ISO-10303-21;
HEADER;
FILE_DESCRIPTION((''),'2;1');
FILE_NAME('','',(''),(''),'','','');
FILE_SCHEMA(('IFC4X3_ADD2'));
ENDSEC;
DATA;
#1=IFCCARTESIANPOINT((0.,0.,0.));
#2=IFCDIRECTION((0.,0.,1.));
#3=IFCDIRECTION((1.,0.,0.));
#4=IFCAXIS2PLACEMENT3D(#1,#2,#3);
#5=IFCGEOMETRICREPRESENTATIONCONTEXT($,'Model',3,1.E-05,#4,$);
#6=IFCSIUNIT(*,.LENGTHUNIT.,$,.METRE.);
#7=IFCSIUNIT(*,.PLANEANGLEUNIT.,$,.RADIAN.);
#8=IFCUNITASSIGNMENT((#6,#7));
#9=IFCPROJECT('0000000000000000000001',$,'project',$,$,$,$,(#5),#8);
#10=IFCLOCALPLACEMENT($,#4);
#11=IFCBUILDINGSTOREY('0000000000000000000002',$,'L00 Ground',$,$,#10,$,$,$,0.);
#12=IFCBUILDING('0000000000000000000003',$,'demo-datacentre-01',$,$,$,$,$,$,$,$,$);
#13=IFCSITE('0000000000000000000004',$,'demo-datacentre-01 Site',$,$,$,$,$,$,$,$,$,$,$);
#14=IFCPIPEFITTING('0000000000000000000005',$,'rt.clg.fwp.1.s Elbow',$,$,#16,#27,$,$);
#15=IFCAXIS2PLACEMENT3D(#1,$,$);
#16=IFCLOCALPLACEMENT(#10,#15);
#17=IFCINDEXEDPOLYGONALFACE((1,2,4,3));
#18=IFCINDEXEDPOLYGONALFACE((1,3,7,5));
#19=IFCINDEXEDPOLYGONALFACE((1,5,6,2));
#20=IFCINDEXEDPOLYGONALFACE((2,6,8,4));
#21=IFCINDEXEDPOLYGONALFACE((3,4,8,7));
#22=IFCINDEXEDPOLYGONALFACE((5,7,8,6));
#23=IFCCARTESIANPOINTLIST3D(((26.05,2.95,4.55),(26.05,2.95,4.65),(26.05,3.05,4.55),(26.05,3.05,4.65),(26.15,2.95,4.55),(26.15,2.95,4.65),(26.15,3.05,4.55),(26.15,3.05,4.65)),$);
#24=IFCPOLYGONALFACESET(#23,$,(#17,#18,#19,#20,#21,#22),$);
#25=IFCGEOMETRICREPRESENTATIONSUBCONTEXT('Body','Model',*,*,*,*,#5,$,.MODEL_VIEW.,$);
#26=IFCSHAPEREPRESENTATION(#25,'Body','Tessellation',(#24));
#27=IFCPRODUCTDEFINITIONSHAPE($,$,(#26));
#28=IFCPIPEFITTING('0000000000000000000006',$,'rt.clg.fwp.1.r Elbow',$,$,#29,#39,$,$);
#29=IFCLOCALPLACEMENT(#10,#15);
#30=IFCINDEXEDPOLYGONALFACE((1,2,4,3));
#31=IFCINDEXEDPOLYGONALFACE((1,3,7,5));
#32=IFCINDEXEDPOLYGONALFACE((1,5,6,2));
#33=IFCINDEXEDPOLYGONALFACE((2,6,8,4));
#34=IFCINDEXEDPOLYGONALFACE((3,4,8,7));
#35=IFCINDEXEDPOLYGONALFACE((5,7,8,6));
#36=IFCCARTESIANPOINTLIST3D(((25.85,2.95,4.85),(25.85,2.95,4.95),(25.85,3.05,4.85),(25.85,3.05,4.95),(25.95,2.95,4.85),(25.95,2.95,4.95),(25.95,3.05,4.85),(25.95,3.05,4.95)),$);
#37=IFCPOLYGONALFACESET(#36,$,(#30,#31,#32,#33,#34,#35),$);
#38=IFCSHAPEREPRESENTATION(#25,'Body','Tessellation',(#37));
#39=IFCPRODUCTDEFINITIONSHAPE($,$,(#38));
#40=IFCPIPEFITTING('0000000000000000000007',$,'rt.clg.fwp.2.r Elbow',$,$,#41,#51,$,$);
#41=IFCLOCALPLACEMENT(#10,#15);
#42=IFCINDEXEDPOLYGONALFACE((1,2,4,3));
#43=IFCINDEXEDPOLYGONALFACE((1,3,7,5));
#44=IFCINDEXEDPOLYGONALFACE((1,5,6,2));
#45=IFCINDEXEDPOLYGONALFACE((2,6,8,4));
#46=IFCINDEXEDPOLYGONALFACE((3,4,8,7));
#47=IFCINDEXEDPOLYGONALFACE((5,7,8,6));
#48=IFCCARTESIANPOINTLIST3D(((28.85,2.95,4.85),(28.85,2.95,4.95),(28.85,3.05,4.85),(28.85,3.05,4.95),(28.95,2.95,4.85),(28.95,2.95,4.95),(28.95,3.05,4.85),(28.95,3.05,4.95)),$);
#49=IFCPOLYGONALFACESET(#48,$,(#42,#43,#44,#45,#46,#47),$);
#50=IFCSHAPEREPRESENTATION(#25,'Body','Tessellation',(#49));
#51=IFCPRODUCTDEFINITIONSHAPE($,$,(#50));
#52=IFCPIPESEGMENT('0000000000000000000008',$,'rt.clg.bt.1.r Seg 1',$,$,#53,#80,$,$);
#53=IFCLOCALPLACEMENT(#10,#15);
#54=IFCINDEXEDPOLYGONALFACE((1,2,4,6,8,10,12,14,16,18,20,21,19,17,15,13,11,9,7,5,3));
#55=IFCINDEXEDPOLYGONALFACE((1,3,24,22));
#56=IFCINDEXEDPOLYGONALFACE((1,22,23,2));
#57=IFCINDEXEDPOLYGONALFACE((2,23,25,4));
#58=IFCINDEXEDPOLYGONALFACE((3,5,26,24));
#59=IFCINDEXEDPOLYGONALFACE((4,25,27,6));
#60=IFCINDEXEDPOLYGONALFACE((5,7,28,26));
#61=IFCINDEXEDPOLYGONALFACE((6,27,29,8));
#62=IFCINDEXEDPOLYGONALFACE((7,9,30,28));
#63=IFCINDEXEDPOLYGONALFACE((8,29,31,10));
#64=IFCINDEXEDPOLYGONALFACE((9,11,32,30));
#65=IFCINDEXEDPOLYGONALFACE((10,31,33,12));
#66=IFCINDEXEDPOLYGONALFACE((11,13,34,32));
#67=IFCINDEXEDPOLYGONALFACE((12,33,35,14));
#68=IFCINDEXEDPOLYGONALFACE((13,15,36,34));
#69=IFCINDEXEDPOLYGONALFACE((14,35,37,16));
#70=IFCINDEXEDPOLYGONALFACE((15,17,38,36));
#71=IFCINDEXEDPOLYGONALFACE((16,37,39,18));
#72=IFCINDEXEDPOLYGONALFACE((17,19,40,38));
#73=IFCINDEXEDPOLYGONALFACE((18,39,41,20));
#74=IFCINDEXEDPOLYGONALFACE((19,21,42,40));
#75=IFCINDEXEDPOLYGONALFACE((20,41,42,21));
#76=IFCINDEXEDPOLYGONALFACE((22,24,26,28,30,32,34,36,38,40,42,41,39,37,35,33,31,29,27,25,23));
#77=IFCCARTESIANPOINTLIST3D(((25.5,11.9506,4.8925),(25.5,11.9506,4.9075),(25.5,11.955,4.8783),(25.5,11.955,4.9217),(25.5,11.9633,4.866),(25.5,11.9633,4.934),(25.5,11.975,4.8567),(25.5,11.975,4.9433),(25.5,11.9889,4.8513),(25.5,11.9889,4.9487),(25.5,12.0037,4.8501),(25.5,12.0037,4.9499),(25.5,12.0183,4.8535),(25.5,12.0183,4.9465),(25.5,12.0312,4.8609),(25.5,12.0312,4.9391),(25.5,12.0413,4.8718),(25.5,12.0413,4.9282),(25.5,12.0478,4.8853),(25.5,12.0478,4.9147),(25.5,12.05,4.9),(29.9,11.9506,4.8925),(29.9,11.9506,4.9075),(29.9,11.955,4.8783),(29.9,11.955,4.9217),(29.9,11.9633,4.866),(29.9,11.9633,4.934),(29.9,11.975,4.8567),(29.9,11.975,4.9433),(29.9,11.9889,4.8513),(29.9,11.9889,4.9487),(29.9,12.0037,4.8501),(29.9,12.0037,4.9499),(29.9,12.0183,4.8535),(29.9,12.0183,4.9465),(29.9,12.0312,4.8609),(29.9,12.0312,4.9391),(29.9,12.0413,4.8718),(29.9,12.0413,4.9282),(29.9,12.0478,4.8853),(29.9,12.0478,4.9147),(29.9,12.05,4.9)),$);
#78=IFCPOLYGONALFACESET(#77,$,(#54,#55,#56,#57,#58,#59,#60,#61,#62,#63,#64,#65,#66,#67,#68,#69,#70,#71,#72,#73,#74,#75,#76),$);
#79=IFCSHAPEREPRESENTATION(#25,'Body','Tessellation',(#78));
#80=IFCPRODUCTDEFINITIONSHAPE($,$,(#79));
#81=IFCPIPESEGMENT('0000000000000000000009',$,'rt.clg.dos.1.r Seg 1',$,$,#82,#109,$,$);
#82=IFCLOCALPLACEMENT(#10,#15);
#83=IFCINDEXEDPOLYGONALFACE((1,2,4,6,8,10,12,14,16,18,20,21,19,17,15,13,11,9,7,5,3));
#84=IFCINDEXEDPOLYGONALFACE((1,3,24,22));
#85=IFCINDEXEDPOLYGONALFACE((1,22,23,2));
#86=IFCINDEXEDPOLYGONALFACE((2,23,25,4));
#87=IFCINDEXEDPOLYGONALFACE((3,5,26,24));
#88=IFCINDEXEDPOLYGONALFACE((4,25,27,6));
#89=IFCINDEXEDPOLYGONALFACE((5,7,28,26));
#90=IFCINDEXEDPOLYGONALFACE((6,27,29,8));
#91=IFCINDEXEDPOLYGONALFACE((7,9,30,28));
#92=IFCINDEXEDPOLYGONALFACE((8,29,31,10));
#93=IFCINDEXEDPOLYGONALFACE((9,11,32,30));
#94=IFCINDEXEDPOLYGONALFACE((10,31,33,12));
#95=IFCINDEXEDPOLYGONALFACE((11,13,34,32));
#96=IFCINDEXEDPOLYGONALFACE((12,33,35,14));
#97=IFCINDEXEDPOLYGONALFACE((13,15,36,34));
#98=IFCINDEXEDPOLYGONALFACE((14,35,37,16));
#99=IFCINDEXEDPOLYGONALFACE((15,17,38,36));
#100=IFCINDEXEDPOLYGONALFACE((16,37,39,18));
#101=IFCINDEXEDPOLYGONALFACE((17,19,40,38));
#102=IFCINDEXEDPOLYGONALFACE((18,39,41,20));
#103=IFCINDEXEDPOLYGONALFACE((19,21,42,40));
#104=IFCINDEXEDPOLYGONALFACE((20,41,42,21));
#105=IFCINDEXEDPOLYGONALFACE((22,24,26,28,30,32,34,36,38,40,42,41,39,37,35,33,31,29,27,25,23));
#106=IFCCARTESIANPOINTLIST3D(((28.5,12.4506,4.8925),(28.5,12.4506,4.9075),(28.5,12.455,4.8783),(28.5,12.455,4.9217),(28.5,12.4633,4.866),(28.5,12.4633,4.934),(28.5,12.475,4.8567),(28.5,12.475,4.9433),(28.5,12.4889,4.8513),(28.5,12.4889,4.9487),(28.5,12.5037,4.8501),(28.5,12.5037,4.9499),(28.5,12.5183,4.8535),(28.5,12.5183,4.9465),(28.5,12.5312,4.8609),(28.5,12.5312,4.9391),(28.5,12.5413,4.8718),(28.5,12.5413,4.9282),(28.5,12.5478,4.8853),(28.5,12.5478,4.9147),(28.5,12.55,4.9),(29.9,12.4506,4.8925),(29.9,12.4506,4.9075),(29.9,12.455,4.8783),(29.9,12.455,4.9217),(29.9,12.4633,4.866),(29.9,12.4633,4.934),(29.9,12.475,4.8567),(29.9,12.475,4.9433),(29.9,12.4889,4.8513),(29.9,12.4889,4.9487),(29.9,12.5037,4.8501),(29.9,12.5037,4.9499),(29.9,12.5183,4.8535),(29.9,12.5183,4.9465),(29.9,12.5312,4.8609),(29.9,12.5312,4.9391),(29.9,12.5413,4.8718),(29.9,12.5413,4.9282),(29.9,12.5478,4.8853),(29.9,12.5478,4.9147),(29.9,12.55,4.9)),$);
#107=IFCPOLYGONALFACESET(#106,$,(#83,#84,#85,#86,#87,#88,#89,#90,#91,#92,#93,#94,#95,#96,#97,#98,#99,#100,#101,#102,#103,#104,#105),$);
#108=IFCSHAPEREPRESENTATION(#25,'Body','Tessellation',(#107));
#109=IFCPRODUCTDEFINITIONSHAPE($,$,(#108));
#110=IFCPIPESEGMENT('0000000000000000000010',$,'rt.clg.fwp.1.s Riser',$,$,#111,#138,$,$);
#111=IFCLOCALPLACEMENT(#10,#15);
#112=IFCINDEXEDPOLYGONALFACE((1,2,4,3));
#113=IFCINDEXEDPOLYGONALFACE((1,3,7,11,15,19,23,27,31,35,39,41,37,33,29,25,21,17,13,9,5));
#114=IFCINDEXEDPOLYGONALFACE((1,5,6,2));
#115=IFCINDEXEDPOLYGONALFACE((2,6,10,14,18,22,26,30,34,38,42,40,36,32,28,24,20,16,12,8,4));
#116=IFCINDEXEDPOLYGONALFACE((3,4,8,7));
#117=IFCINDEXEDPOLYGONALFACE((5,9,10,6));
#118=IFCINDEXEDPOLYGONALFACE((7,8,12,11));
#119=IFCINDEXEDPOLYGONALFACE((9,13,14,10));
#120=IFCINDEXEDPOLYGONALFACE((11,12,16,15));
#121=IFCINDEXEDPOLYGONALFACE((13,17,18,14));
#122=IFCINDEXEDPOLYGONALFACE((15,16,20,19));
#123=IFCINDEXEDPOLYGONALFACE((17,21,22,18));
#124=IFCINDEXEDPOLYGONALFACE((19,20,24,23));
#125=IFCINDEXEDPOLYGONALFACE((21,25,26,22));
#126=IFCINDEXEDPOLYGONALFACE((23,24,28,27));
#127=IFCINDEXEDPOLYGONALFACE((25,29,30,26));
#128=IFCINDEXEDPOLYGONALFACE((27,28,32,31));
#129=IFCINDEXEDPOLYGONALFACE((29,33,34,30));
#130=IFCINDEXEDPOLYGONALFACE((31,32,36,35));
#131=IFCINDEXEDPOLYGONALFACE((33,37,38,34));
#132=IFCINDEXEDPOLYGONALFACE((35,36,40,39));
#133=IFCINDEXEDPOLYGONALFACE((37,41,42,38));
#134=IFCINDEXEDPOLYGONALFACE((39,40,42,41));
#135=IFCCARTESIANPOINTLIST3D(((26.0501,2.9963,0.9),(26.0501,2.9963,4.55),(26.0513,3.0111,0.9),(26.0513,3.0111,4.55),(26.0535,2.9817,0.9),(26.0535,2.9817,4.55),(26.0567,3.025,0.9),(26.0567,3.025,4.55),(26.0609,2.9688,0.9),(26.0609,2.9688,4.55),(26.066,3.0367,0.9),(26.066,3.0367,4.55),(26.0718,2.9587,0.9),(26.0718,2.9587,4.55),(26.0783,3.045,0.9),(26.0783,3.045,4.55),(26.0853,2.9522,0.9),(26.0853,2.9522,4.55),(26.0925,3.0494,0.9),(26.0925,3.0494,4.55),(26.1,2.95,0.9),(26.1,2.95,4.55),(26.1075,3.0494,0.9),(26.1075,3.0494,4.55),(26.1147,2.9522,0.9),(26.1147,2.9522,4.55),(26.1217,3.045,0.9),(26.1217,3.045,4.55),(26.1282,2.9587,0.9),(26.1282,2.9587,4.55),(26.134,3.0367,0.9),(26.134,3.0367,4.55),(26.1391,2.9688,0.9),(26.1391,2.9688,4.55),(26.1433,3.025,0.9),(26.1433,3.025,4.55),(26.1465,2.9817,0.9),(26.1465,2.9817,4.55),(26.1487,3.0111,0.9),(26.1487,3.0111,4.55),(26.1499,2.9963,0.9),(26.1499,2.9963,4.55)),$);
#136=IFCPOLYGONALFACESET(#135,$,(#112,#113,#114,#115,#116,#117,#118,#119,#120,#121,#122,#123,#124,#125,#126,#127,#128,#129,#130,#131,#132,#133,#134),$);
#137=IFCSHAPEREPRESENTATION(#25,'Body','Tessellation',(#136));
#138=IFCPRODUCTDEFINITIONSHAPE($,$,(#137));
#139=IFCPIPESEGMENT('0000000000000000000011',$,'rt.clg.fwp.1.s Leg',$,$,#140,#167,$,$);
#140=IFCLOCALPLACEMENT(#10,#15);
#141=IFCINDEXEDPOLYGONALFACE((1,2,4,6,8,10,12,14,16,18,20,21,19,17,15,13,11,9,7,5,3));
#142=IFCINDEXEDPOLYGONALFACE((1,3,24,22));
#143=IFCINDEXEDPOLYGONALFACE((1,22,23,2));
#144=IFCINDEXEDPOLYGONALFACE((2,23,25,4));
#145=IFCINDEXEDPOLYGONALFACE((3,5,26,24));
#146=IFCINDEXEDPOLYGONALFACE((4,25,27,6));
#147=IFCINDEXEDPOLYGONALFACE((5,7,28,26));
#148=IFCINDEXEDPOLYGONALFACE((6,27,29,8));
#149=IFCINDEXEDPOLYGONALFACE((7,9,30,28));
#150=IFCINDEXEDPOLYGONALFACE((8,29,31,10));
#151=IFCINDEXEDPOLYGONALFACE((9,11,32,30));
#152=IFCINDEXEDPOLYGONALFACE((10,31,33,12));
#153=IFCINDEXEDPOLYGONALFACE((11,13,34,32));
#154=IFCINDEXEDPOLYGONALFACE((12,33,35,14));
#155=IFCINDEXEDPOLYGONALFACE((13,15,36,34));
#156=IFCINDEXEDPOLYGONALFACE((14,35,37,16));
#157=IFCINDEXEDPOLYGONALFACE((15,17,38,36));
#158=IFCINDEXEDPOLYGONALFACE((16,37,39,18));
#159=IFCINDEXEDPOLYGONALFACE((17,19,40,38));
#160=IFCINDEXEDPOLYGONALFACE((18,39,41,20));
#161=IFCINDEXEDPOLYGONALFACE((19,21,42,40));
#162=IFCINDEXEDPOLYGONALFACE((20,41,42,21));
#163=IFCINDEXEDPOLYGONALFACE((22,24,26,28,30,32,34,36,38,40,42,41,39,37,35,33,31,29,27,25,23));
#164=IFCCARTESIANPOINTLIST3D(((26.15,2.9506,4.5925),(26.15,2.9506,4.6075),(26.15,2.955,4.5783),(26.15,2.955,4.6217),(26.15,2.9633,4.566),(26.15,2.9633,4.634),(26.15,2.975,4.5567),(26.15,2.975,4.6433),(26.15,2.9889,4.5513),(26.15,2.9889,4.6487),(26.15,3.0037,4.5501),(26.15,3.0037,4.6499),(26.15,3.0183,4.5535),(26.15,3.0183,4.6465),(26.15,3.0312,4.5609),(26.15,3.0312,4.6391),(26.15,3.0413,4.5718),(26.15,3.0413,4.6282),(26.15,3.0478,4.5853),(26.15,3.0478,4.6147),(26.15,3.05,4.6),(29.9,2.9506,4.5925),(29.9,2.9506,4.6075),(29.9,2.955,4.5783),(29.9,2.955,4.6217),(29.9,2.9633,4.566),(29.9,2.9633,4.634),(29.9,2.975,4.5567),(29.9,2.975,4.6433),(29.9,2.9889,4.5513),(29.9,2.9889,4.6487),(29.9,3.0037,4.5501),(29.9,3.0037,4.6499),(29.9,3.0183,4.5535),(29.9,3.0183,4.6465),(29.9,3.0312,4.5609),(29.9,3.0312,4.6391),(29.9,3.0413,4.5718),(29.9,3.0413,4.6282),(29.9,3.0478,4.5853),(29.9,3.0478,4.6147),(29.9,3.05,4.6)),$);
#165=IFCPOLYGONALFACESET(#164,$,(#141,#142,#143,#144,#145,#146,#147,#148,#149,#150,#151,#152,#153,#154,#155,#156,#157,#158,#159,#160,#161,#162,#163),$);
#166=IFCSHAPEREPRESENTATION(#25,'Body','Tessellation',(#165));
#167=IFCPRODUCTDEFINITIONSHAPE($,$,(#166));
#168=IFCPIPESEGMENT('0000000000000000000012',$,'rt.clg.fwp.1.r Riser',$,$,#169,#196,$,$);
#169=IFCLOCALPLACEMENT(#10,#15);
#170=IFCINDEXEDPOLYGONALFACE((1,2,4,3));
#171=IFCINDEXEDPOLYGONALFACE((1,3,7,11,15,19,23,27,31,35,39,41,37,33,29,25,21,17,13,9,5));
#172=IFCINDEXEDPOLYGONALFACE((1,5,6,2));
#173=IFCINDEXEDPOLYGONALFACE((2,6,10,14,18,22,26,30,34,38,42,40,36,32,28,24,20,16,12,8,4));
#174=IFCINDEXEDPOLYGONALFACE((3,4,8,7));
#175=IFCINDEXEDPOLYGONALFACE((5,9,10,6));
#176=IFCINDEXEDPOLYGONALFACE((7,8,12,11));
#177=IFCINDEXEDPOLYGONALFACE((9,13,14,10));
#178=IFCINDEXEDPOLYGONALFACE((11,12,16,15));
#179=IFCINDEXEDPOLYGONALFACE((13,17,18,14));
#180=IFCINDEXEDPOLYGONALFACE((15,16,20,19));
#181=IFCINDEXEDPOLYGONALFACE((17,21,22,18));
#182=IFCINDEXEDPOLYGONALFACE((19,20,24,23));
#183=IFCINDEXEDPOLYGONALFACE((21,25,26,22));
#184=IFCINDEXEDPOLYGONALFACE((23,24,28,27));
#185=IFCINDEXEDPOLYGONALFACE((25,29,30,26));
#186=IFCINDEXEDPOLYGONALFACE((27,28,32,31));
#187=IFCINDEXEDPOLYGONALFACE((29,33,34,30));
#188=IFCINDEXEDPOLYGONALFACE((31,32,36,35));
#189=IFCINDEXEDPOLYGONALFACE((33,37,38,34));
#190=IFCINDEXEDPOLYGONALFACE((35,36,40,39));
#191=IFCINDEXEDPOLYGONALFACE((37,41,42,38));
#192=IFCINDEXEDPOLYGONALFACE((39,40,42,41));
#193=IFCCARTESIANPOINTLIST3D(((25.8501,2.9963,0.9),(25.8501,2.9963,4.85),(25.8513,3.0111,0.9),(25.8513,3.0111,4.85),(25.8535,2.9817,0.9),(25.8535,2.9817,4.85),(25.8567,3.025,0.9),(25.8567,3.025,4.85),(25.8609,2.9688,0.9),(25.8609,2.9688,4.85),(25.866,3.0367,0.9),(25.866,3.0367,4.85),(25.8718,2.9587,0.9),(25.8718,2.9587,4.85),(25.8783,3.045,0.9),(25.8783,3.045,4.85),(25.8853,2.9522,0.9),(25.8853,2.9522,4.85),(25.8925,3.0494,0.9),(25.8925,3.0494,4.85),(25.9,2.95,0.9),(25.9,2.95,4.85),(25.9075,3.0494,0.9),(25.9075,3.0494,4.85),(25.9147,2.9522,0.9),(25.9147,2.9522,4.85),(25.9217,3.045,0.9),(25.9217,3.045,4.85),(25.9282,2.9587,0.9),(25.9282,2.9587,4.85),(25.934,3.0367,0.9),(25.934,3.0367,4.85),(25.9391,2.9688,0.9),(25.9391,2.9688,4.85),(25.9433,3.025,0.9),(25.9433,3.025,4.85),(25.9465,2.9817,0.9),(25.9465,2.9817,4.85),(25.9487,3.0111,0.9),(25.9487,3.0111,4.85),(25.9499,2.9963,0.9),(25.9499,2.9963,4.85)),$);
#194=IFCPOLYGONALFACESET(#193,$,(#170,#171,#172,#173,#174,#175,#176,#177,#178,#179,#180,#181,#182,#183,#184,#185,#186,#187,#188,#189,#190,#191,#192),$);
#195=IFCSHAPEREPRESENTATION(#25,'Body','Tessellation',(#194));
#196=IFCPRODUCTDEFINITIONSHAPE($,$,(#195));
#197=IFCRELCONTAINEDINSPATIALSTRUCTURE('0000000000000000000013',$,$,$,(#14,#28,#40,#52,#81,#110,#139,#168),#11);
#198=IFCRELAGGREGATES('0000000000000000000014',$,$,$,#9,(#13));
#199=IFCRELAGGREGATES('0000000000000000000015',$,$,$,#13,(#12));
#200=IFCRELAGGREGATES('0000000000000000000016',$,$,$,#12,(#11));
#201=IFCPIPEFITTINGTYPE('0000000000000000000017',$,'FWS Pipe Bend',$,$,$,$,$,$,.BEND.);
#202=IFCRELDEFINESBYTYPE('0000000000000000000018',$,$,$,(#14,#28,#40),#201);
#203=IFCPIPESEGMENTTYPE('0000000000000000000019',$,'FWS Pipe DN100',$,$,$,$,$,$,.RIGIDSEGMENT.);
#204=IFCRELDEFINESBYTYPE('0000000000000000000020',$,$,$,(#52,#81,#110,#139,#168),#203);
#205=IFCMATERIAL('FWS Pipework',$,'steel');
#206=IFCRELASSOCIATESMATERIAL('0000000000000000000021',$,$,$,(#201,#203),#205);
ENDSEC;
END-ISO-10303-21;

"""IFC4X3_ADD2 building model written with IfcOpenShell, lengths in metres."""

from ifc_helpers import new_model, si_unit, frame, origin_with_axes, place, context, subcontext, project, spatial, rectangle, circle, extrude, material, type_object, element, save


model = new_model("IFC4X3_ADD2")

# Units and contexts
model_context = context("Model", 3, precision=1e-05, world=origin_with_axes())
body_context = subcontext(model_context, "Body", "Model", "MODEL_VIEW")
ifc_project = project(units=[si_unit("LENGTHUNIT", "METRE"), si_unit("PLANEANGLEUNIT", "RADIAN")], contexts=[model_context])

# Site, building, storey
site = spatial("IfcSite", under=ifc_project, Name="demo-datacentre-01 Site")
building = spatial("IfcBuilding", under=site, Name="demo-datacentre-01")
storey_placement = place(None, origin_with_axes())
storey = spatial("IfcBuildingStorey", under=building, at=storey_placement, Name="L00 Ground", Elevation=0.0)

# Pipe fittings
ifc_material_1 = material(Name="FWS Pipework", Category="steel")
pipe_fitting_type = type_object("IfcPipeFittingType", Name="FWS Pipe Bend", PredefinedType="BEND", material=ifc_material_1)
for number, where, z_axis, x_axis, name in (
    (1, (26.1, 3.0, 4.55), (0.0, 0.0, 1.0), (1.0, 0.0, 0.0), "rt.clg.fwp.1.s Elbow"),
    (2, (25.9, 3.0, 4.85), (0.0, 0.0, 1.0), (1.0, 0.0, 0.0), "rt.clg.fwp.1.r Elbow"),
    (3, (28.9, 3.0, 4.85), (0.0, 0.0, 1.0), (1.0, 0.0, 0.0), "rt.clg.fwp.2.r Elbow"),
):
    element("IfcPipeFitting", number, at=place(storey_placement, frame(where, z_axis=z_axis, x_axis=x_axis)), inside=storey, type_object=pipe_fitting_type, Name=name, context=body_context, shape_type="SweptSolid", body=[
        extrude(rectangle(XDim=0.1, YDim=0.1), origin_with_axes(), (0.0, 0.0, 1.0), 0.1),
    ])

# Pipe segments
pipe_segment_type_1 = type_object("IfcPipeSegmentType", Name="FWS Pipe DN100", PredefinedType="RIGIDSEGMENT", material=ifc_material_1)
pipe_segment_1_placement = place(storey_placement, frame((25.5, 12.0, 4.9), z_axis=(1.0, 0.0, 0.0), x_axis=(0.0, 1.0, 0.0)))
element("IfcPipeSegment", 4, at=pipe_segment_1_placement, inside=storey, type_object=pipe_segment_type_1, Name="rt.clg.bt.1.r Seg 1", context=body_context, shape_type="SweptSolid", body=[
    extrude(circle(Radius=0.05), origin_with_axes(), (0.0, 0.0, 1.0), 4.4),
])
pipe_segment_2_placement = place(storey_placement, frame((28.5, 12.5, 4.9), z_axis=(1.0, 0.0, 0.0), x_axis=(0.0, 1.0, 0.0)))
element("IfcPipeSegment", 5, at=pipe_segment_2_placement, inside=storey, type_object=pipe_segment_type_1, Name="rt.clg.dos.1.r Seg 1", context=body_context, shape_type="SweptSolid", body=[
    extrude(circle(Radius=0.05), origin_with_axes(), (0.0, 0.0, 1.0), 1.4),
])
pipe_segment_3_placement = place(storey_placement, frame((26.1, 3.0, 0.9), z_axis=(0.0, 0.0, 1.0), x_axis=(0.0, -1.0, 0.0)))
element("IfcPipeSegment", 6, at=pipe_segment_3_placement, inside=storey, type_object=pipe_segment_type_1, Name="rt.clg.fwp.1.s Riser", context=body_context, shape_type="SweptSolid", body=[
    extrude(circle(Radius=0.05), origin_with_axes(), (0.0, 0.0, 1.0), 3.65),
])
pipe_segment_4_placement = place(storey_placement, frame((26.15, 3.0, 4.6), z_axis=(1.0, 0.0, 0.0), x_axis=(0.0, 1.0, 0.0)))
element("IfcPipeSegment", 7, at=pipe_segment_4_placement, inside=storey, type_object=pipe_segment_type_1, Name="rt.clg.fwp.1.s Leg", context=body_context, shape_type="SweptSolid", body=[
    extrude(circle(Radius=0.05), origin_with_axes(), (0.0, 0.0, 1.0), 3.75),
])
pipe_segment_5_placement = place(storey_placement, frame((25.9, 3.0, 0.9), z_axis=(0.0, 0.0, 1.0), x_axis=(0.0, -1.0, 0.0)))
element("IfcPipeSegment", 8, at=pipe_segment_5_placement, inside=storey, type_object=pipe_segment_type_1, Name="rt.clg.fwp.1.r Riser", context=body_context, shape_type="SweptSolid", body=[
    extrude(circle(Radius=0.05), origin_with_axes(), (0.0, 0.0, 1.0), 3.95),
])

save(model, "model.ifc")
